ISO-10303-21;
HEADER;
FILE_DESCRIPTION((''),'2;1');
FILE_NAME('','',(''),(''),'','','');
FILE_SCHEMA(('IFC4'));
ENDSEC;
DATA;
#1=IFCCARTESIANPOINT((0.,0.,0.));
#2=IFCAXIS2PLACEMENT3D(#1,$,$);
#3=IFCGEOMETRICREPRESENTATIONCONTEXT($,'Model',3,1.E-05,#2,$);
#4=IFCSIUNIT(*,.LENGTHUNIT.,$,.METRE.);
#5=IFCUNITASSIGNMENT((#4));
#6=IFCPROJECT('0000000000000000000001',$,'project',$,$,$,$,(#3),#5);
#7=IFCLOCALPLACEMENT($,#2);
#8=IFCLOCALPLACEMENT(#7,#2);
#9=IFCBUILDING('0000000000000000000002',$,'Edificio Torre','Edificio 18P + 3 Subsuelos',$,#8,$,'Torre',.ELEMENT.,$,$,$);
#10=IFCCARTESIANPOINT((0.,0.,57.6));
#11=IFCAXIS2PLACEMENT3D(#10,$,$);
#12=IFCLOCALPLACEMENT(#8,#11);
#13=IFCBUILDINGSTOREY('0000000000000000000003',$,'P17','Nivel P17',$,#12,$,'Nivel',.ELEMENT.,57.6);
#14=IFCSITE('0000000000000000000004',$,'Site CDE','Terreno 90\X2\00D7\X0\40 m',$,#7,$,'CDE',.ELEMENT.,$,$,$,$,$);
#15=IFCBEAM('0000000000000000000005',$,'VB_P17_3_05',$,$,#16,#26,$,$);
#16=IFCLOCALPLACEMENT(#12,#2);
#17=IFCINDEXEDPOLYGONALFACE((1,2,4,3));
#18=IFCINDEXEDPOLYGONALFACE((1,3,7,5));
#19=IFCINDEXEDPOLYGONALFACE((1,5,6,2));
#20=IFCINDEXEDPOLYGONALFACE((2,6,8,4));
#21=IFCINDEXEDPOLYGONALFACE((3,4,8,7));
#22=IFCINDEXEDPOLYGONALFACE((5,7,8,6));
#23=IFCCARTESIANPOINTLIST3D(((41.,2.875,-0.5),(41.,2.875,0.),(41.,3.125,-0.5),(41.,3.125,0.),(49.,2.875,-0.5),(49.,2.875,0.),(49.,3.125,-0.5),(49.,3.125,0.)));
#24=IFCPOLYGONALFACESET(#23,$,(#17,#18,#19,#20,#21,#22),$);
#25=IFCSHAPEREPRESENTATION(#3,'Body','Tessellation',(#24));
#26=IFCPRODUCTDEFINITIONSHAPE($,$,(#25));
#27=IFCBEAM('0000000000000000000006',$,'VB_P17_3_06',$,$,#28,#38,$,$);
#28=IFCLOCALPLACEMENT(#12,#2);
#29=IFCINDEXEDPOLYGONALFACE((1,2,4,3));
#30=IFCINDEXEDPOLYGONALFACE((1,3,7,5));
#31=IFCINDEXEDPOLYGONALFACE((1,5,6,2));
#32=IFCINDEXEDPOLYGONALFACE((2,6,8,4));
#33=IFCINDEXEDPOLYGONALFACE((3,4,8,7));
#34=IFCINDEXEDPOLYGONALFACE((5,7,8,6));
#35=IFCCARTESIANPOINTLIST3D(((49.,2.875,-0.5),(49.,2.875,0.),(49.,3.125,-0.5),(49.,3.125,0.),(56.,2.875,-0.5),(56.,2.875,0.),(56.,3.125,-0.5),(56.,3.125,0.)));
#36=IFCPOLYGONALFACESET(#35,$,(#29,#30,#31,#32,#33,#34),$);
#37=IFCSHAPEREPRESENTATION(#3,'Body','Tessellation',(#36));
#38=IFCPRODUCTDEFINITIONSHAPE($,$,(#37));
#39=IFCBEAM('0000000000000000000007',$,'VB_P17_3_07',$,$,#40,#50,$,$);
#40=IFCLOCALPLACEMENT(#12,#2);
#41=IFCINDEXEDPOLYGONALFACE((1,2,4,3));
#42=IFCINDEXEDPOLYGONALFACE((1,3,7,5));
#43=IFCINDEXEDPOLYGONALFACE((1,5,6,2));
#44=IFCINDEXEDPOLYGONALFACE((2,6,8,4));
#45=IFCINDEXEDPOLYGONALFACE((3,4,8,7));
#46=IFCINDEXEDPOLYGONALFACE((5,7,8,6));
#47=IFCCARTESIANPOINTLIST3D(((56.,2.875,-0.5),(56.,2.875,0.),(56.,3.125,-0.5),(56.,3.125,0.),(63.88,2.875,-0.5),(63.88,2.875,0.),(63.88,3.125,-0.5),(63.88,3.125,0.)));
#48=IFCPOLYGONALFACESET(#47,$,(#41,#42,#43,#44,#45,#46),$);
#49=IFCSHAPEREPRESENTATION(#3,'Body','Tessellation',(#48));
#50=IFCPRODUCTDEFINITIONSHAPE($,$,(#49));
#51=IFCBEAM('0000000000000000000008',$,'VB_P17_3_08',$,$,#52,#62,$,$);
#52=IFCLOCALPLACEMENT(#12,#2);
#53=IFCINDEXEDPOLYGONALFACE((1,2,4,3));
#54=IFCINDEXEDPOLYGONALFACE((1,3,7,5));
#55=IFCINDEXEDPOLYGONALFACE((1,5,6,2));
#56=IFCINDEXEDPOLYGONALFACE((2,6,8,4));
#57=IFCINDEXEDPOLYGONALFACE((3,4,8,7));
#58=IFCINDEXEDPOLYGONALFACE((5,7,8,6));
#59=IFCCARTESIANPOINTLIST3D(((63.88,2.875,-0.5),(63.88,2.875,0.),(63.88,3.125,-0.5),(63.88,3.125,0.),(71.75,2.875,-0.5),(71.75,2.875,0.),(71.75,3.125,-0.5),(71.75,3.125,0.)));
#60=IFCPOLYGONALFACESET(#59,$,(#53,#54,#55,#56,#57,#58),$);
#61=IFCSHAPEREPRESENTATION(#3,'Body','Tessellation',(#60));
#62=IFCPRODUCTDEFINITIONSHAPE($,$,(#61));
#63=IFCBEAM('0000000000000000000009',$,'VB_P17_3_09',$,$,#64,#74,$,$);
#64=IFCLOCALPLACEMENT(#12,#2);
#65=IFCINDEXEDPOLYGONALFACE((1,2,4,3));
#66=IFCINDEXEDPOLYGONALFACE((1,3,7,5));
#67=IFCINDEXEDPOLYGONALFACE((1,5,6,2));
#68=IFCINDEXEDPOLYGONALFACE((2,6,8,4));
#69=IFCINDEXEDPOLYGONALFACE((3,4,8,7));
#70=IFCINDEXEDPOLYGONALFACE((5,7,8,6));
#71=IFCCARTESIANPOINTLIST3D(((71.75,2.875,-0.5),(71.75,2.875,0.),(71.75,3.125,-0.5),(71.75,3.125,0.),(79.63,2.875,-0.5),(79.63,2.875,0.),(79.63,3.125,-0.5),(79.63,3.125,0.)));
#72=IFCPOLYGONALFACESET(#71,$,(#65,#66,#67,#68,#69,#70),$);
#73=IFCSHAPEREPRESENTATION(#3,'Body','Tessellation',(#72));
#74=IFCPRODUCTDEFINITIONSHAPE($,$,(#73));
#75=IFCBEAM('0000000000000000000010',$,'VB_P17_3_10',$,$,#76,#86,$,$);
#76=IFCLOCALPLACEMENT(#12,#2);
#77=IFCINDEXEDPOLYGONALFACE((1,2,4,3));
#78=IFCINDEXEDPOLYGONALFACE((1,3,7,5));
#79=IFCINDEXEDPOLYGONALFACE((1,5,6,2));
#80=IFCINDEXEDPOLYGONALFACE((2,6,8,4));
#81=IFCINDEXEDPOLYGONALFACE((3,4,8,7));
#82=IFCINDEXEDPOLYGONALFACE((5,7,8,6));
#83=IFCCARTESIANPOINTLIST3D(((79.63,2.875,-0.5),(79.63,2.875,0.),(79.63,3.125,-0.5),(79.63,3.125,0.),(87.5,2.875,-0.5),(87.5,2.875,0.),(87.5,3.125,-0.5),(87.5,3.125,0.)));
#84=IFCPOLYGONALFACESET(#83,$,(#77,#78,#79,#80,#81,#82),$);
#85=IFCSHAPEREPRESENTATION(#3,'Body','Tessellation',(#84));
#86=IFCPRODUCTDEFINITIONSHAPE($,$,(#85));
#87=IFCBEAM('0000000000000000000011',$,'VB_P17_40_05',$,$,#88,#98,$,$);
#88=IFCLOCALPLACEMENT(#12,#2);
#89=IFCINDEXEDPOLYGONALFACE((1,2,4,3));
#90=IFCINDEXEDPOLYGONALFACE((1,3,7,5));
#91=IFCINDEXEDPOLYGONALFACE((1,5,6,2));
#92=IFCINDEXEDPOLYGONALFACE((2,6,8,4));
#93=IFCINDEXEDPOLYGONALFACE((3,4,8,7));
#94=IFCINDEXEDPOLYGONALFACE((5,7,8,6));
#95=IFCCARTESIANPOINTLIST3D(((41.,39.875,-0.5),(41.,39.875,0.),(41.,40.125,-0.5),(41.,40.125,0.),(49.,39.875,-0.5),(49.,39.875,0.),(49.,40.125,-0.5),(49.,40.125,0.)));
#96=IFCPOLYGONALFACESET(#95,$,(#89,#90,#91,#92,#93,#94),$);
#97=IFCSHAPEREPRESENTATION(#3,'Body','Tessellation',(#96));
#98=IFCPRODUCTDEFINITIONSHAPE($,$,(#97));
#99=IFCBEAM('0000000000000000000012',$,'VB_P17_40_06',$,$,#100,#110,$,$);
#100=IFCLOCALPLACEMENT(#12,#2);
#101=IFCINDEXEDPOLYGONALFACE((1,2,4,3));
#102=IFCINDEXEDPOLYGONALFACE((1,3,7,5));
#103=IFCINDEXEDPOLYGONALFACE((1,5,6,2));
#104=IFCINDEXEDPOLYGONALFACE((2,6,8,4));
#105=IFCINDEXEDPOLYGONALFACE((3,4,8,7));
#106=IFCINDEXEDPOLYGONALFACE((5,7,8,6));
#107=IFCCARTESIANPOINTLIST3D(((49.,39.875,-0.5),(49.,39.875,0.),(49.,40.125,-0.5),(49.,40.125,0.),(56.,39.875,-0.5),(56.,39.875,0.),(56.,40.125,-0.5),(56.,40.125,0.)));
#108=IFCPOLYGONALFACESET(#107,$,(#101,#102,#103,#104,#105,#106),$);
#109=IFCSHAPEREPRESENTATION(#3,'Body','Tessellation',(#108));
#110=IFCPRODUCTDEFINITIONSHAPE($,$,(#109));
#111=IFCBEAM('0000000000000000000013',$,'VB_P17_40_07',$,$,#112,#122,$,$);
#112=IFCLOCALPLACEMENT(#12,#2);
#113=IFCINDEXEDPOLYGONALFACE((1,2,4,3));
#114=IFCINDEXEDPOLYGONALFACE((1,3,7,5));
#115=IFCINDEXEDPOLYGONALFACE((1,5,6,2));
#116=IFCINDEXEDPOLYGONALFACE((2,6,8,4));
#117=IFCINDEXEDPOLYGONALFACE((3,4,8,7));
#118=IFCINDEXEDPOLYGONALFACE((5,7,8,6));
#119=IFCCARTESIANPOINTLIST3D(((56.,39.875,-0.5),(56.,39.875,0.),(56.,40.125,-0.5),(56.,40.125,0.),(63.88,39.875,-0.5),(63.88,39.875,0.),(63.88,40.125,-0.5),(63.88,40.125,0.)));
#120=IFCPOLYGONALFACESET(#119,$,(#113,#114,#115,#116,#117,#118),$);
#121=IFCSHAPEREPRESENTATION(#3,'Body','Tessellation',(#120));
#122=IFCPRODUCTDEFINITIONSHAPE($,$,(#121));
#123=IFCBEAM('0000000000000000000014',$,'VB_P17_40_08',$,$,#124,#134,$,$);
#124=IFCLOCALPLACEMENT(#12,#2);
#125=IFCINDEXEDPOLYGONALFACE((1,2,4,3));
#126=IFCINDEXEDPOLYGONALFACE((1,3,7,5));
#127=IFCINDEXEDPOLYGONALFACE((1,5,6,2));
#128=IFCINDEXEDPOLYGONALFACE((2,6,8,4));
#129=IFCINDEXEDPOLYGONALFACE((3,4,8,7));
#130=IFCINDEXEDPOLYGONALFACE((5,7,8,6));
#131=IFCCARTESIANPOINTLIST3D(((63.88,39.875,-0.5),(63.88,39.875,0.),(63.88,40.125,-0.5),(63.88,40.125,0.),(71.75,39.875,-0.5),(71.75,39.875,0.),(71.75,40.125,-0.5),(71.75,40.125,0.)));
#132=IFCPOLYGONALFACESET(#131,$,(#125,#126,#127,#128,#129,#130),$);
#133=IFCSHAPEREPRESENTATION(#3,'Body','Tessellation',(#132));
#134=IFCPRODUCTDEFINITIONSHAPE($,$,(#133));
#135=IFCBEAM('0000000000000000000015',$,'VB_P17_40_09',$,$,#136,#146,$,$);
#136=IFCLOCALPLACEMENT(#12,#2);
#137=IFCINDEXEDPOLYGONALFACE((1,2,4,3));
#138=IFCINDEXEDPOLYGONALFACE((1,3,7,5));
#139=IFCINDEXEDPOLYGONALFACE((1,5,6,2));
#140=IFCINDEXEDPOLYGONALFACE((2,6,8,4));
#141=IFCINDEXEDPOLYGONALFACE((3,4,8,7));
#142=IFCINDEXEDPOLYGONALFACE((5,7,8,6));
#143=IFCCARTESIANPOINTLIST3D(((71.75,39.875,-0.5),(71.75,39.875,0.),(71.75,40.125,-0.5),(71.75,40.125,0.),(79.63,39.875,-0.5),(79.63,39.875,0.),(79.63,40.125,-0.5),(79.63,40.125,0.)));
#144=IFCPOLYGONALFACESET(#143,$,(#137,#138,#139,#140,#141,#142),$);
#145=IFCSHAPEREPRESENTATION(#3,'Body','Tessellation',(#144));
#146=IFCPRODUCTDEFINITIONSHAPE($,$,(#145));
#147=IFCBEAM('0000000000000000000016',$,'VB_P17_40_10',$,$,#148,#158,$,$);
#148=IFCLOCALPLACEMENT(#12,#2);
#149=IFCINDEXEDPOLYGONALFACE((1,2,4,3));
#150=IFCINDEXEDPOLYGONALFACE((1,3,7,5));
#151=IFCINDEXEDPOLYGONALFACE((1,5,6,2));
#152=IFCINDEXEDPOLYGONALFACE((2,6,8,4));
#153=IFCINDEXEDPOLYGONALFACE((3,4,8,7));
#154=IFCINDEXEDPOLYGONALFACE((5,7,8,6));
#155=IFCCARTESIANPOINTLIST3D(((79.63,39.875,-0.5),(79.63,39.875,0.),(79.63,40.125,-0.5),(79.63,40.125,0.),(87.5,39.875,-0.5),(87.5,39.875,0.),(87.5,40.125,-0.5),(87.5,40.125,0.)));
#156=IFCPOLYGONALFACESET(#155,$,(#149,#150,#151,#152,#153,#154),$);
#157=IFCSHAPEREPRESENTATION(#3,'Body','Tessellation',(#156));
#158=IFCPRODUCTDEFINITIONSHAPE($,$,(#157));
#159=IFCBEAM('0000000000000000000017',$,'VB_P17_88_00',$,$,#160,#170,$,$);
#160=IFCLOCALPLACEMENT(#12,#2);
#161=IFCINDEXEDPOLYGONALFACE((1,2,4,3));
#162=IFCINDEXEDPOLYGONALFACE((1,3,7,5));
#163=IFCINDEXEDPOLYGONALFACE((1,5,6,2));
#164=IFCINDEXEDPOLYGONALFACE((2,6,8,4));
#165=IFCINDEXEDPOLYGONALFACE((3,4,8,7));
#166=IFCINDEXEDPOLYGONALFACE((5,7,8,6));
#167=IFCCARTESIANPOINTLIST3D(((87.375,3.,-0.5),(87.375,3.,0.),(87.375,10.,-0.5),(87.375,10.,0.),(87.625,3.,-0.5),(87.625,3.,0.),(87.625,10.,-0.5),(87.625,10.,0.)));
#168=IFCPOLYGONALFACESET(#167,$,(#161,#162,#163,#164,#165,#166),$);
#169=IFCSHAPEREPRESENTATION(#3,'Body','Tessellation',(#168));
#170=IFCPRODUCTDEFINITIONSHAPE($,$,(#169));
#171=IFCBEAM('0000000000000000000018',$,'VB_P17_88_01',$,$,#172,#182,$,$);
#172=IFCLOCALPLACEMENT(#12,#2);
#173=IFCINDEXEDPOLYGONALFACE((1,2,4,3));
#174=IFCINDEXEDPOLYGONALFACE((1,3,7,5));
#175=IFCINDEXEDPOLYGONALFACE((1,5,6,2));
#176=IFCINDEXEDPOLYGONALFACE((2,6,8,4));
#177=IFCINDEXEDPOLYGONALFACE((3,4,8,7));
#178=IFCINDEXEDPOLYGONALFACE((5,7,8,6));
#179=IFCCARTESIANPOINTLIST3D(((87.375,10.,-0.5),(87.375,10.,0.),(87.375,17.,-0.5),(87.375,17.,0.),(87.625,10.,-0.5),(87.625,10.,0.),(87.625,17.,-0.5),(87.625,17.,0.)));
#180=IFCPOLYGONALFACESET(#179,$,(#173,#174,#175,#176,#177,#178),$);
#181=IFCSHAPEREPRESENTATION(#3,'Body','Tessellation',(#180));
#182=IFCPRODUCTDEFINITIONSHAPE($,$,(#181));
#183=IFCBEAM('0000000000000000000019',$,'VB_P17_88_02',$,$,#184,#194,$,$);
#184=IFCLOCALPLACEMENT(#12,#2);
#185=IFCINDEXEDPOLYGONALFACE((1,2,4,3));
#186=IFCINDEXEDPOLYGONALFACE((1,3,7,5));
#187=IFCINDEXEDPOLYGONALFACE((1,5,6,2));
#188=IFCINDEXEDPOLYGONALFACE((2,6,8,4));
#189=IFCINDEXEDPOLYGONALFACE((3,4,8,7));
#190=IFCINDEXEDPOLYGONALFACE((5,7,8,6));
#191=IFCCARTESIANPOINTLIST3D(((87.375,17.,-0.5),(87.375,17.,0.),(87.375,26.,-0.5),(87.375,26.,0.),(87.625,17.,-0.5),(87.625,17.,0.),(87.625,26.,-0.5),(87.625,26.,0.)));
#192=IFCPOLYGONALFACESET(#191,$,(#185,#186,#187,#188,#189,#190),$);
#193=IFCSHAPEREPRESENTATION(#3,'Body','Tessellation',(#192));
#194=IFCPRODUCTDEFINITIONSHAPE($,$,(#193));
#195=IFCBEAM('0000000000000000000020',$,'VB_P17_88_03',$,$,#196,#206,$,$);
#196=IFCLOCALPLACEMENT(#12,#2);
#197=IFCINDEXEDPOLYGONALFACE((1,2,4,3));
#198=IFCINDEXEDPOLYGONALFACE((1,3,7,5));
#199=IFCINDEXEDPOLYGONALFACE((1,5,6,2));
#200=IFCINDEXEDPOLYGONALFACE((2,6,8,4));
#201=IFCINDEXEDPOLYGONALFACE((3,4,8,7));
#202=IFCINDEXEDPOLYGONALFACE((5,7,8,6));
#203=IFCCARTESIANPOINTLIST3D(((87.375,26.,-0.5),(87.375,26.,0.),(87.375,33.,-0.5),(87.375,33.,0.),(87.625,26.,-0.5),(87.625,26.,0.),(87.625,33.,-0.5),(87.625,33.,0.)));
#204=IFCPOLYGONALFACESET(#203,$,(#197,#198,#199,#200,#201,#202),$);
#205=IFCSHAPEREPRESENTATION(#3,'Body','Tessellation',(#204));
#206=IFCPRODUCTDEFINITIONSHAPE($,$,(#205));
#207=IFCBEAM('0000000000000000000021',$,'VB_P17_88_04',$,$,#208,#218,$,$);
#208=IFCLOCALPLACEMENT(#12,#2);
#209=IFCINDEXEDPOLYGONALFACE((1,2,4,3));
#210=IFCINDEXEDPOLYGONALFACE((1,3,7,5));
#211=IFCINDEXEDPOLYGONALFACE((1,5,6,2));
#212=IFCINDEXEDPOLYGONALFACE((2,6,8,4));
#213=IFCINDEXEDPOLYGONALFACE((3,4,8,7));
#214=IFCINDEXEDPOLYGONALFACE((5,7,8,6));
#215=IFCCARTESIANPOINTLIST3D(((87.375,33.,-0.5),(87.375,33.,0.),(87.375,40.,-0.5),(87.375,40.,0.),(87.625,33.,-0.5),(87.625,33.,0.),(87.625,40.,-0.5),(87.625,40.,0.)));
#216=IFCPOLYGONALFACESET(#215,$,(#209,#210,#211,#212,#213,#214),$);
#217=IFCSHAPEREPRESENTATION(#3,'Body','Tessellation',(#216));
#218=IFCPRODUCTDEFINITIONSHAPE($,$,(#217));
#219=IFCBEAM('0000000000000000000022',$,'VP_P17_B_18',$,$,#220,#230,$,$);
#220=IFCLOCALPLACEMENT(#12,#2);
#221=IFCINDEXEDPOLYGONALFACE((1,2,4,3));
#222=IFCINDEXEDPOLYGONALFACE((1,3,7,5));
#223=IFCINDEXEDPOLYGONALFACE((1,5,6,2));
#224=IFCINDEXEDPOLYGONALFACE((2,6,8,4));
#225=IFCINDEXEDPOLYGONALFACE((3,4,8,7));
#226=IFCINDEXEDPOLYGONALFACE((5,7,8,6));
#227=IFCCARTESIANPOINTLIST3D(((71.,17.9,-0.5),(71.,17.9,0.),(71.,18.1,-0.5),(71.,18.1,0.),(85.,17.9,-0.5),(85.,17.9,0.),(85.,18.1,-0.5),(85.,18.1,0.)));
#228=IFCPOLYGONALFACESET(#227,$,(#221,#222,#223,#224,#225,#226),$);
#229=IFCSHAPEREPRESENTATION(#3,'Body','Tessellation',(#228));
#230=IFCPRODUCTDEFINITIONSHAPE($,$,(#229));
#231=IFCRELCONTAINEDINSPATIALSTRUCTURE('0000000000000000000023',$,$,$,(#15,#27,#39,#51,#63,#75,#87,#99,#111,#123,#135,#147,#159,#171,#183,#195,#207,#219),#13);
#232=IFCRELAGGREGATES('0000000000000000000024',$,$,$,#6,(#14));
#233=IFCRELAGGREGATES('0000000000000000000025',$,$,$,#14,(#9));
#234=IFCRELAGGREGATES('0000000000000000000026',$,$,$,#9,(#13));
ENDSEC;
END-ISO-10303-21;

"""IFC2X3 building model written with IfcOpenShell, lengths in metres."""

from ifc_helpers import new_model, si_unit, frame, origin, origin_2d, place, context, project, spatial, rectangle, extrude, element, save


model = new_model("IFC2X3")

# Units and contexts
model_context = context("Model", 3, precision=1e-05, world=origin())
ifc_project = project(units=[si_unit("LENGTHUNIT", "METRE")], contexts=[model_context])

# Site, building, storey
site_placement = place(None, origin())
site = spatial("IfcSite", under=ifc_project, at=site_placement, Name="Site CDE", Description="Terreno 90×40 m", LongName="CDE", CompositionType="ELEMENT")
building_placement = place(site_placement, origin())
building = spatial("IfcBuilding", under=site, at=building_placement, Name="Edificio Torre", Description="Edificio 18P + 3 Subsuelos", LongName="Torre", CompositionType="ELEMENT")
storey_placement = place(building_placement, frame((0.0, 0.0, 57.6)))
storey = spatial("IfcBuildingStorey", under=building, at=storey_placement, Name="P17", Description="Nivel P17", LongName="Nivel", CompositionType="ELEMENT", Elevation=57.6)

# Beams
beam_1_placement = place(storey_placement, frame((45.0, 3.0, -0.5)))
element("IfcBeam", 1, at=beam_1_placement, inside=storey, Name="VB_P17_3_05", context=model_context, shape_type="SweptSolid", body=[
    extrude(rectangle(XDim=8.0, YDim=0.25, at=origin_2d()), origin(), (0.0, 0.0, 1.0), 0.5),
])
beam_2_placement = place(storey_placement, frame((52.5, 3.0, -0.5)))
element("IfcBeam", 2, at=beam_2_placement, inside=storey, Name="VB_P17_3_06", context=model_context, shape_type="SweptSolid", body=[
    extrude(rectangle(XDim=7.0, YDim=0.25, at=origin_2d()), origin(), (0.0, 0.0, 1.0), 0.5),
])
beam_3_placement = place(storey_placement, frame((59.94, 3.0, -0.5)))
element("IfcBeam", 3, at=beam_3_placement, inside=storey, Name="VB_P17_3_07", context=model_context, shape_type="SweptSolid", body=[
    extrude(rectangle(XDim=7.88, YDim=0.25, at=origin_2d()), origin(), (0.0, 0.0, 1.0), 0.5),
])
beam_4_placement = place(storey_placement, frame((67.815, 3.0, -0.5)))
element("IfcBeam", 4, at=beam_4_placement, inside=storey, Name="VB_P17_3_08", context=model_context, shape_type="SweptSolid", body=[
    extrude(rectangle(XDim=7.87, YDim=0.25, at=origin_2d()), origin(), (0.0, 0.0, 1.0), 0.5),
])
beam_5_placement = place(storey_placement, frame((75.69, 3.0, -0.5)))
element("IfcBeam", 5, at=beam_5_placement, inside=storey, Name="VB_P17_3_09", context=model_context, shape_type="SweptSolid", body=[
    extrude(rectangle(XDim=7.88, YDim=0.25, at=origin_2d()), origin(), (0.0, 0.0, 1.0), 0.5),
])
beam_6_placement = place(storey_placement, frame((83.565, 3.0, -0.5)))
element("IfcBeam", 6, at=beam_6_placement, inside=storey, Name="VB_P17_3_10", context=model_context, shape_type="SweptSolid", body=[
    extrude(rectangle(XDim=7.87, YDim=0.25, at=origin_2d()), origin(), (0.0, 0.0, 1.0), 0.5),
])
beam_7_placement = place(storey_placement, frame((45.0, 40.0, -0.5)))
element("IfcBeam", 7, at=beam_7_placement, inside=storey, Name="VB_P17_40_05", context=model_context, shape_type="SweptSolid", body=[
    extrude(rectangle(XDim=8.0, YDim=0.25, at=origin_2d()), origin(), (0.0, 0.0, 1.0), 0.5),
])
beam_8_placement = place(storey_placement, frame((52.5, 40.0, -0.5)))
element("IfcBeam", 8, at=beam_8_placement, inside=storey, Name="VB_P17_40_06", context=model_context, shape_type="SweptSolid", body=[
    extrude(rectangle(XDim=7.0, YDim=0.25, at=origin_2d()), origin(), (0.0, 0.0, 1.0), 0.5),
])
beam_9_placement = place(storey_placement, frame((59.94, 40.0, -0.5)))
element("IfcBeam", 9, at=beam_9_placement, inside=storey, Name="VB_P17_40_07", context=model_context, shape_type="SweptSolid", body=[
    extrude(rectangle(XDim=7.88, YDim=0.25, at=origin_2d()), origin(), (0.0, 0.0, 1.0), 0.5),
])
beam_10_placement = place(storey_placement, frame((67.815, 40.0, -0.5)))
element("IfcBeam", 10, at=beam_10_placement, inside=storey, Name="VB_P17_40_08", context=model_context, shape_type="SweptSolid", body=[
    extrude(rectangle(XDim=7.87, YDim=0.25, at=origin_2d()), origin(), (0.0, 0.0, 1.0), 0.5),
])
beam_11_placement = place(storey_placement, frame((75.69, 40.0, -0.5)))
element("IfcBeam", 11, at=beam_11_placement, inside=storey, Name="VB_P17_40_09", context=model_context, shape_type="SweptSolid", body=[
    extrude(rectangle(XDim=7.88, YDim=0.25, at=origin_2d()), origin(), (0.0, 0.0, 1.0), 0.5),
])
beam_12_placement = place(storey_placement, frame((83.565, 40.0, -0.5)))
element("IfcBeam", 12, at=beam_12_placement, inside=storey, Name="VB_P17_40_10", context=model_context, shape_type="SweptSolid", body=[
    extrude(rectangle(XDim=7.87, YDim=0.25, at=origin_2d()), origin(), (0.0, 0.0, 1.0), 0.5),
])
for number, where, name in (
    (13, (87.5, 6.5, -0.5), "VB_P17_88_00"),
    (14, (87.5, 13.5, -0.5), "VB_P17_88_01"),
):
    element("IfcBeam", number, at=place(storey_placement, frame(where)), inside=storey, Name=name, context=model_context, shape_type="SweptSolid", body=[
        extrude(rectangle(XDim=0.25, YDim=7.0, at=origin_2d()), origin(), (0.0, 0.0, 1.0), 0.5),
    ])
beam_13_placement = place(storey_placement, frame((87.5, 21.5, -0.5)))
element("IfcBeam", 15, at=beam_13_placement, inside=storey, Name="VB_P17_88_02", context=model_context, shape_type="SweptSolid", body=[
    extrude(rectangle(XDim=0.25, YDim=9.0, at=origin_2d()), origin(), (0.0, 0.0, 1.0), 0.5),
])
for number, where, name in (
    (16, (87.5, 29.5, -0.5), "VB_P17_88_03"),
    (17, (87.5, 36.5, -0.5), "VB_P17_88_04"),
):
    element("IfcBeam", number, at=place(storey_placement, frame(where)), inside=storey, Name=name, context=model_context, shape_type="SweptSolid", body=[
        extrude(rectangle(XDim=0.25, YDim=7.0, at=origin_2d()), origin(), (0.0, 0.0, 1.0), 0.5),
    ])
for number, where, name in (
    (18, (78.0, 18.0, -0.5), "VP_P17_B_18"),
):
    element("IfcBeam", number, at=place(storey_placement, frame(where)), inside=storey, Name=name, context=model_context, shape_type="SweptSolid", body=[
        extrude(rectangle(XDim=14.0, YDim=0.2, at=origin_2d()), origin(), (0.0, 0.0, 1.0), 0.5),
    ])

save(model, "model.ifc")
